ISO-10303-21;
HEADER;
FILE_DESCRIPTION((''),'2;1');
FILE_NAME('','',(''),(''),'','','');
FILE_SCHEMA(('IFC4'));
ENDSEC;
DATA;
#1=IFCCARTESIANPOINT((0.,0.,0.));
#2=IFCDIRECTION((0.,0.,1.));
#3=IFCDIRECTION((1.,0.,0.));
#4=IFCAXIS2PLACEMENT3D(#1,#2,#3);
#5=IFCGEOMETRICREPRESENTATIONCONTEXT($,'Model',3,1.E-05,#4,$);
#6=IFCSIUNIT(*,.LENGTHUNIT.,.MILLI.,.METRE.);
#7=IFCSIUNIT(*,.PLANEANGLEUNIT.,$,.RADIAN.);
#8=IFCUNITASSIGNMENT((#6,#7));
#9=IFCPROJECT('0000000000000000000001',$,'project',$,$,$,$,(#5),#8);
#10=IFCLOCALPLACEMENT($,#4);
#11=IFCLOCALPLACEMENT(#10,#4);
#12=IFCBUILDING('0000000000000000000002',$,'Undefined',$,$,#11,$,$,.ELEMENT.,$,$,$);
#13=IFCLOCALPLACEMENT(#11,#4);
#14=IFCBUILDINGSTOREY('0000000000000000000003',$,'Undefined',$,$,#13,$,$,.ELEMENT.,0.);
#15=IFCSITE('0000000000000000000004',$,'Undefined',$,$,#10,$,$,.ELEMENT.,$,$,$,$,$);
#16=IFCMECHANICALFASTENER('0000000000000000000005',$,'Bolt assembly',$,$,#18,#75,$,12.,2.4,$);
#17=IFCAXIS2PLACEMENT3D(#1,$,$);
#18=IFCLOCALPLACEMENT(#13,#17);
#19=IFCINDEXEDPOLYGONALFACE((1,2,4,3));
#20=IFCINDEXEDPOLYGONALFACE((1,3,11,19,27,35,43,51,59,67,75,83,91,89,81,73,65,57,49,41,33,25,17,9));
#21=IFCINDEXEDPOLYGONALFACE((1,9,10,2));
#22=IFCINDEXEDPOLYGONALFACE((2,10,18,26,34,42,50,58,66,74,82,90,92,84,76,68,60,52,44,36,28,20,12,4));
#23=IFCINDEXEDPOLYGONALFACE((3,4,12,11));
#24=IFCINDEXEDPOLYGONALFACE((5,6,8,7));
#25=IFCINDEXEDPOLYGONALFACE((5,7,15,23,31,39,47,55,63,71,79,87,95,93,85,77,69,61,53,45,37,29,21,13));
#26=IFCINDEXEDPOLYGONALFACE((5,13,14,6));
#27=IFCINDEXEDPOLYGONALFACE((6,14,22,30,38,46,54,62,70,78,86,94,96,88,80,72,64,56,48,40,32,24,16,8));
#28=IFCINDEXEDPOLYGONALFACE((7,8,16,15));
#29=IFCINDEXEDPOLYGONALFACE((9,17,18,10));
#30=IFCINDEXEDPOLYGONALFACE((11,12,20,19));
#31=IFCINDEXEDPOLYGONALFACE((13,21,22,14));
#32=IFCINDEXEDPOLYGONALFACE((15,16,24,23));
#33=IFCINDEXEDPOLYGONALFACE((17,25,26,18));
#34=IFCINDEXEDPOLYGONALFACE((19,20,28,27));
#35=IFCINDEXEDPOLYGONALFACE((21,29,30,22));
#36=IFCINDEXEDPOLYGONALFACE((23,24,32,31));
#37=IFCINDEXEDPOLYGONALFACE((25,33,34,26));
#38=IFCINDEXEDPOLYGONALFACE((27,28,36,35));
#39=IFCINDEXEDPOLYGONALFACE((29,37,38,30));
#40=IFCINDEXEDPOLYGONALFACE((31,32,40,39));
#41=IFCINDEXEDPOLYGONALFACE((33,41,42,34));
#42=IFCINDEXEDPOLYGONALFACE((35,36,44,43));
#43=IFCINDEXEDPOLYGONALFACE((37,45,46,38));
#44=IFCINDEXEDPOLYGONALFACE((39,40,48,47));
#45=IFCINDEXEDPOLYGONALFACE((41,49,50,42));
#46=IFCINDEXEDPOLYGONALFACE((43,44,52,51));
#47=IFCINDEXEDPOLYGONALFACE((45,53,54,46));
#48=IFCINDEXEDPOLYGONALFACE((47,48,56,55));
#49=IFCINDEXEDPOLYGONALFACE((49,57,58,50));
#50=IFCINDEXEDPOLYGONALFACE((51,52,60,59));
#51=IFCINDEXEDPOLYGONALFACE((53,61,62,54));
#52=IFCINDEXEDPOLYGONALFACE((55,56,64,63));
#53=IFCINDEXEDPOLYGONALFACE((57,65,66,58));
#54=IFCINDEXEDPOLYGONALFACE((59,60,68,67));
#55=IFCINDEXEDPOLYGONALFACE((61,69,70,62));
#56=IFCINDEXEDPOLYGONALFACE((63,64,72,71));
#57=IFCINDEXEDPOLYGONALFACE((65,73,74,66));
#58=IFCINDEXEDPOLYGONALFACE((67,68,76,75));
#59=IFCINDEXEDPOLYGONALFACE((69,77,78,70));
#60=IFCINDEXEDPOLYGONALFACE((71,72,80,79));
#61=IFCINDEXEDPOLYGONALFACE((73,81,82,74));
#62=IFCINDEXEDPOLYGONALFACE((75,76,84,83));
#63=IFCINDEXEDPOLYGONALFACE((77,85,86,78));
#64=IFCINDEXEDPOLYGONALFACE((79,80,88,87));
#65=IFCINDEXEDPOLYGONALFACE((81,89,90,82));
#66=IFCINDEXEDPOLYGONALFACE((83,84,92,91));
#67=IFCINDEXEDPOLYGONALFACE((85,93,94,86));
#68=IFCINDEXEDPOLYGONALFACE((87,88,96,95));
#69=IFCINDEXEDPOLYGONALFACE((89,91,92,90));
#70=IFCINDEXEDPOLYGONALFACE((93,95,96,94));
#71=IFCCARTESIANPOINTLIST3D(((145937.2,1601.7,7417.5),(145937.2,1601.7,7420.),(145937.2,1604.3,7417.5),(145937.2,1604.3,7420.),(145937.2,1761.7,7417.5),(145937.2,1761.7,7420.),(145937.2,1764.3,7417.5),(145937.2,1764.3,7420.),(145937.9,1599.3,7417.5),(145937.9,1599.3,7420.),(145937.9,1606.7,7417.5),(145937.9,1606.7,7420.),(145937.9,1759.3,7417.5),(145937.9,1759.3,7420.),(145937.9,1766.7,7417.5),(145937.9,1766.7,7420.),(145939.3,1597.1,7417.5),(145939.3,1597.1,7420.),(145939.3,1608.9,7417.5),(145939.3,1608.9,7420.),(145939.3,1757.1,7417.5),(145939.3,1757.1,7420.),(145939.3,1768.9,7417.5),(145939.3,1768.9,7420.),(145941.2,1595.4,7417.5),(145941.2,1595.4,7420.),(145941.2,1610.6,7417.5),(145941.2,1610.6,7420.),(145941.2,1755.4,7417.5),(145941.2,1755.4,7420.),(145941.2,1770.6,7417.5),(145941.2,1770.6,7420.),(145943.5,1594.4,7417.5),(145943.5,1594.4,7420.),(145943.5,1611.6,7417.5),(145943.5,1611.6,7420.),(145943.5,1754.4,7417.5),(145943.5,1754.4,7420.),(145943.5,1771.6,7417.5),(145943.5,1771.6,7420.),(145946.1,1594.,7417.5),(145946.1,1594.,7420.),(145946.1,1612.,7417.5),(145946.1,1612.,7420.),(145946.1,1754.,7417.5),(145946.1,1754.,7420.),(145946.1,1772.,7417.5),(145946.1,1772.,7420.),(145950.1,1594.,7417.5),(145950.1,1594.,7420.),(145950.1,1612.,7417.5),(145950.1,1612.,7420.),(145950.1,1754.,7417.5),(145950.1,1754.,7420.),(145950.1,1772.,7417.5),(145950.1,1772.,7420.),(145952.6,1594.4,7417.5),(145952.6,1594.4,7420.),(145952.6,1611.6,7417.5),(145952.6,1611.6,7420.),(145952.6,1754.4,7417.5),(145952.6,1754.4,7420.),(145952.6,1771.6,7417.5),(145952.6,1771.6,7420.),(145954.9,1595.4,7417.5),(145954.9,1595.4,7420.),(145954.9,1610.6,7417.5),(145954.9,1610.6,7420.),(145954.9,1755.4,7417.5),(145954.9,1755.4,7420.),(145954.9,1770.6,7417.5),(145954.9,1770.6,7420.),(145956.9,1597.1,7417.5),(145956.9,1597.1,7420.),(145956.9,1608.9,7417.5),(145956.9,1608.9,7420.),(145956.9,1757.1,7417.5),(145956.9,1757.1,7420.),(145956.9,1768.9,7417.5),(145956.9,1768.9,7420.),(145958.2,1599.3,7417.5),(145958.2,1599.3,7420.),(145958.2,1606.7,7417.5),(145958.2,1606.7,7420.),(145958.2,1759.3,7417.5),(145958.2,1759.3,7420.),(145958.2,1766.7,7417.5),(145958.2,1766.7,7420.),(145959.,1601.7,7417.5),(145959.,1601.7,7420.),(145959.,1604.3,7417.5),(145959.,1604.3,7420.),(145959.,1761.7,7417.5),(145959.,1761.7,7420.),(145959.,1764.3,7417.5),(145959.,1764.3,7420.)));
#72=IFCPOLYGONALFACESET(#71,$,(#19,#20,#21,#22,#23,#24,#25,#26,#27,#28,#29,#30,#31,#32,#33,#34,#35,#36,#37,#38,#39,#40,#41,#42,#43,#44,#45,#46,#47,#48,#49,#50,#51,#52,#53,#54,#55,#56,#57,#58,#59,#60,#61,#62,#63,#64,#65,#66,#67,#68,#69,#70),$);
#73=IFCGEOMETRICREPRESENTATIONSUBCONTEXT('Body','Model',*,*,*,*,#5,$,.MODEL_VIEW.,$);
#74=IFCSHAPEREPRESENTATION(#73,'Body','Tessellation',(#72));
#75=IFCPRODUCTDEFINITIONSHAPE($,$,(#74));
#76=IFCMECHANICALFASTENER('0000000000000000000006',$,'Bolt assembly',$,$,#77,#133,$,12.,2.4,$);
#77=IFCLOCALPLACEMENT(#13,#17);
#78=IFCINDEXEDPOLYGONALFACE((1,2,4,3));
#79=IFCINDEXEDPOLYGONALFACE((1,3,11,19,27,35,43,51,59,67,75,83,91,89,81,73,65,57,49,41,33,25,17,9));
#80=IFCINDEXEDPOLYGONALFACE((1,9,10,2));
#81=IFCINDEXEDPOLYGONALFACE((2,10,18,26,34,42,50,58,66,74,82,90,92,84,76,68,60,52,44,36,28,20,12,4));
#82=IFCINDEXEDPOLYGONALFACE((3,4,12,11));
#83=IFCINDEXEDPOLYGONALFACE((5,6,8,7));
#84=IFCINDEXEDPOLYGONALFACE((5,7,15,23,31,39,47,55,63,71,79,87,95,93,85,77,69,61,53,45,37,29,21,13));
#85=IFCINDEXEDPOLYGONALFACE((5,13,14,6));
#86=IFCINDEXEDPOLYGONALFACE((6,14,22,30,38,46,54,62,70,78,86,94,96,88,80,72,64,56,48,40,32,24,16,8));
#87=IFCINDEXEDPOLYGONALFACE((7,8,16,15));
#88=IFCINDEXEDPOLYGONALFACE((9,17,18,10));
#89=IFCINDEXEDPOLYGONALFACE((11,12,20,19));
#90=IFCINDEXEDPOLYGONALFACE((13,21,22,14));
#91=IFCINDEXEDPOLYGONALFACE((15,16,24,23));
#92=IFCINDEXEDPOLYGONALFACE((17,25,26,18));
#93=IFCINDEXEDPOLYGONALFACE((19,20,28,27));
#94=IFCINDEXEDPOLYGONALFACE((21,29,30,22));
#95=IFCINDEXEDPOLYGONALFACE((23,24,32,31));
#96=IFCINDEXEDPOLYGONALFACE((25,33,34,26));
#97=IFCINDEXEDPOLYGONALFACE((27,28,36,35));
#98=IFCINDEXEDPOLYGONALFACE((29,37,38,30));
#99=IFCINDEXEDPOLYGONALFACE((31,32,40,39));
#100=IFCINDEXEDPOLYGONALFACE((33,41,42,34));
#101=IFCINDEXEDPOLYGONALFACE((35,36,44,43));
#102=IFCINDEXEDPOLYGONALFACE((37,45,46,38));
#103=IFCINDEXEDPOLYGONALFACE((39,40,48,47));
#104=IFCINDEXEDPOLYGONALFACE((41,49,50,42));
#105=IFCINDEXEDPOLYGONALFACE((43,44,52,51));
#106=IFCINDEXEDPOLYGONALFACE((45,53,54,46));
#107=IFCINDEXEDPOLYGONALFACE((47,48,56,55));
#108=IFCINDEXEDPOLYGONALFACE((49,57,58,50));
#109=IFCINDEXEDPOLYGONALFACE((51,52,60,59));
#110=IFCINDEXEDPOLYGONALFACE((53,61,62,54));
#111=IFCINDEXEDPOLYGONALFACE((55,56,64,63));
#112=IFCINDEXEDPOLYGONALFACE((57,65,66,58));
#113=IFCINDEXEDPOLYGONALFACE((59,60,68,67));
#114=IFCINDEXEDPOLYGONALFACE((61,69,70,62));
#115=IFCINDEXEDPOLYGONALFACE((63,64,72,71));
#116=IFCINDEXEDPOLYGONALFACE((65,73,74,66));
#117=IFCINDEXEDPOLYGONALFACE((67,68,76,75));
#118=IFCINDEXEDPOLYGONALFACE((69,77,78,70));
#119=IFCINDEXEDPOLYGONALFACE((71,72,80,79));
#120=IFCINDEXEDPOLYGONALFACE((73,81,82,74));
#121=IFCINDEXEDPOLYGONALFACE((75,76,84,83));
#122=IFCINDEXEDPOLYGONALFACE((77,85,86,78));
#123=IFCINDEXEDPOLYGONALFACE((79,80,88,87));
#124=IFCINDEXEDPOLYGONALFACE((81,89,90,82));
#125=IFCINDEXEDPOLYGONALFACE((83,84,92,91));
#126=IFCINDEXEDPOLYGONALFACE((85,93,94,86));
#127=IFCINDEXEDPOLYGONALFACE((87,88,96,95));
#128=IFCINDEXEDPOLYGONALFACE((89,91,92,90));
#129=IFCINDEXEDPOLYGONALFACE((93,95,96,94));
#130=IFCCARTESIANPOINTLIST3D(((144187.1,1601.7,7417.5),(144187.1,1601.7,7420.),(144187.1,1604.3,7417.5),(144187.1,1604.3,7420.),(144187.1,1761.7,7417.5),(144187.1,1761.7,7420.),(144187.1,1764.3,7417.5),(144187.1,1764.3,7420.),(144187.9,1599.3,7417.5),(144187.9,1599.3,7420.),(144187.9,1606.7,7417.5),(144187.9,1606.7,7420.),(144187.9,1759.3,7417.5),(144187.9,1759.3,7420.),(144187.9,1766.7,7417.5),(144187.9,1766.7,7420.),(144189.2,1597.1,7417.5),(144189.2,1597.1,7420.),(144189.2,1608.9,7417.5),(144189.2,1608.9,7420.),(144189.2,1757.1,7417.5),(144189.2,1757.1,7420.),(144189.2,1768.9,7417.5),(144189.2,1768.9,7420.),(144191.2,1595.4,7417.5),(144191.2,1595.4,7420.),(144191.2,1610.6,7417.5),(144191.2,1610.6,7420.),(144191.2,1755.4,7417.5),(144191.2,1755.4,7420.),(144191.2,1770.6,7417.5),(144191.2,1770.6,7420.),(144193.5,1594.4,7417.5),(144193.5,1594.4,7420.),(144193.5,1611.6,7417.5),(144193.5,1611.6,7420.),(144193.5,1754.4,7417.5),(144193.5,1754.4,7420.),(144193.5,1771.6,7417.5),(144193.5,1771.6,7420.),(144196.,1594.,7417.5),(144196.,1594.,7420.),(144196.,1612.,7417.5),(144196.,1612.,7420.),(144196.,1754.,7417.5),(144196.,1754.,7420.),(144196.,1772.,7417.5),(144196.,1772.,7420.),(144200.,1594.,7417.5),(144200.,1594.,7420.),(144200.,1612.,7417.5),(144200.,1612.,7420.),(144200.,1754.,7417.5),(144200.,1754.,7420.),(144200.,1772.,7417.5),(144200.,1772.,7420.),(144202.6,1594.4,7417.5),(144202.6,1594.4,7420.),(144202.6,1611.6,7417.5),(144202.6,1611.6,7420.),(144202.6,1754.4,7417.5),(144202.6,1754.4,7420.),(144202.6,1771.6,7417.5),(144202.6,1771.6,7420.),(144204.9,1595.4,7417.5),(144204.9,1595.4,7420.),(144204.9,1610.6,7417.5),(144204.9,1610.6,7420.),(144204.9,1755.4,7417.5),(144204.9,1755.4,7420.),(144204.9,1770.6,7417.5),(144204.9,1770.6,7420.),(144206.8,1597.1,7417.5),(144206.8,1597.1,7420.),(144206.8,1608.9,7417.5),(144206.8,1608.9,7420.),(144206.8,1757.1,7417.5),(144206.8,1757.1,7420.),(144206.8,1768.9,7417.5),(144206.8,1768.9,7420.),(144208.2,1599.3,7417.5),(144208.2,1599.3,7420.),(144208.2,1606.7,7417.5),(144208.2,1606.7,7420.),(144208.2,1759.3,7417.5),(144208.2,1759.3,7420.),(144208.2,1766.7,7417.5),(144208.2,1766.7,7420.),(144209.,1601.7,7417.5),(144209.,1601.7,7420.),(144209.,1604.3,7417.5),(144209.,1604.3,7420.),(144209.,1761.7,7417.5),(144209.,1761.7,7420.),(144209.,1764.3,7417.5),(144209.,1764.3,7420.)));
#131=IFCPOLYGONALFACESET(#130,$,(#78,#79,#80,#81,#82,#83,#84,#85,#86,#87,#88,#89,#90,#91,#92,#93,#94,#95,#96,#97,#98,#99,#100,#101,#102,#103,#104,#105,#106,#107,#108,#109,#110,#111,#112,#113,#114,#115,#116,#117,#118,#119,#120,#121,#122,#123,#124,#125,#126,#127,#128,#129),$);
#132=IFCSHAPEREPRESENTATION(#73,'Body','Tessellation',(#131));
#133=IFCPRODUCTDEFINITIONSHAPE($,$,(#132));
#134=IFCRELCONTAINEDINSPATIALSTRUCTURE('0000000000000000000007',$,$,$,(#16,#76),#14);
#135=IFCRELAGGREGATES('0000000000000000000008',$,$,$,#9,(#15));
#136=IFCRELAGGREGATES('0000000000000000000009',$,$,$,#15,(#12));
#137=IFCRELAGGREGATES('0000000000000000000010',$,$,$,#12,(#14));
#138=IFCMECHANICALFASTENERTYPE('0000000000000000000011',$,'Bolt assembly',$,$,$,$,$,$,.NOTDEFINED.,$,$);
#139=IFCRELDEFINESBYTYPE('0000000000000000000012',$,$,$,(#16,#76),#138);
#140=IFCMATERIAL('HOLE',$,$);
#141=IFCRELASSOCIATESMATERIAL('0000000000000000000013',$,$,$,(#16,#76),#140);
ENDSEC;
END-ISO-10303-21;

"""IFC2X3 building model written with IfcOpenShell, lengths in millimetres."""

from ifc_helpers import new_model, si_unit, frame, frame_2d, origin_with_axes, place, context, subcontext, project, spatial, polyline, circle_curve, parameter, trimmed, segment, composite_curve, outline, extrude, source, transform, mapped, material, type_object, element, save


model = new_model("IFC2X3")

# Units and contexts
model_context = context("Model", 3, precision=1e-05, world=origin_with_axes())
body_context = subcontext(model_context, "Body", "Model", "MODEL_VIEW")
ifc_project = project(units=[si_unit("LENGTHUNIT", "METRE", prefix="MILLI"), si_unit("PLANEANGLEUNIT", "RADIAN")], contexts=[model_context])

# Site, building, storey
site_placement = place(None, origin_with_axes())
site = spatial("IfcSite", under=ifc_project, at=site_placement, Name="Undefined", CompositionType="ELEMENT")
building_placement = place(site_placement, origin_with_axes())
building = spatial("IfcBuilding", under=site, at=building_placement, Name="Undefined", CompositionType="ELEMENT")
storey_placement = place(building_placement, origin_with_axes())
storey = spatial("IfcBuildingStorey", under=building, at=storey_placement, Name="Undefined", CompositionType="ELEMENT", Elevation=0.0)

# Mechanical fasteners
mechanical_fastener_type = type_object("IfcMechanicalFastenerType", Name="Bolt assembly")
ifc_material_1 = material(Name="HOLE")
shared_shape_1 = source(origin_with_axes(), body_context, "Body", "SweptSolid", [
    extrude(outline(composite_curve([segment(polyline([(-2.0, 9.0), (2.0, 9.0)]), True, "CONTINUOUS"), segment(trimmed(circle_curve(frame_2d((2.0, 0.0), x_axis=(0.0, 1.0)), 9.0), [parameter(0.0)], [parameter(3.141593)], False, "PARAMETER"), True, "CONTINUOUS"), segment(polyline([(2.0, -9.0), (-2.0, -9.0)]), True, "CONTINUOUS"), segment(trimmed(circle_curve(frame_2d((-2.0, 0.0), x_axis=(0.0, -1.0)), 9.0), [parameter(0.0)], [parameter(3.141593)], False, "PARAMETER"), True, "DISCONTINUOUS")], self_intersect=False)), frame((0.0, -2.4, 0.0), z_axis=(0.0, 1.0, 0.0), x_axis=(1.0, 0.0, 0.0)), (0.0, 0.0, 1.0), 2.5),
])
mechanical_fastener_1_placement = place(storey_placement, frame((145948.1, 1683.0, 7417.6), z_axis=(0.0, -1.0, 0.0), x_axis=(-1.0, 0.0, 0.0)))
element("IfcMechanicalFastener", 1, at=mechanical_fastener_1_placement, inside=storey, type_object=mechanical_fastener_type, material=ifc_material_1, Name="Bolt assembly", NominalDiameter=12.0, NominalLength=2.4, context=body_context, shape_type="MappedRepresentation", body=[
    mapped(shared_shape_1, transform((0.0, 0.0, -80.0))),
    mapped(shared_shape_1, transform((0.0, 0.0, 80.0))),
])
shared_shape_2 = source(origin_with_axes(), body_context, "Body", "SweptSolid", [
    extrude(outline(composite_curve([segment(polyline([(-2.0, 9.0), (2.0, 9.0)]), True, "CONTINUOUS"), segment(trimmed(circle_curve(frame_2d((2.0, 0.0), x_axis=(0.0, 1.0)), 9.0), [parameter(0.0)], [parameter(3.141593)], False, "PARAMETER"), True, "CONTINUOUS"), segment(polyline([(2.0, -9.0), (-2.0, -9.0)]), True, "CONTINUOUS"), segment(trimmed(circle_curve(frame_2d((-2.0, 0.0), x_axis=(0.0, -1.0)), 9.0), [parameter(0.0)], [parameter(3.141593)], False, "PARAMETER"), True, "DISCONTINUOUS")], self_intersect=False)), frame((0.0, -2.4, 0.0), z_axis=(0.0, 1.0, 0.0), x_axis=(1.0, 0.0, 0.0)), (0.0, 0.0, 1.0), 2.5),
])
mechanical_fastener_2_placement = place(storey_placement, frame((144198.0, 1683.0, 7417.6), z_axis=(0.0, -1.0, 0.0), x_axis=(-1.0, 0.0, 0.0)))
element("IfcMechanicalFastener", 2, at=mechanical_fastener_2_placement, inside=storey, type_object=mechanical_fastener_type, material=ifc_material_1, Name="Bolt assembly", NominalDiameter=12.0, NominalLength=2.4, context=body_context, shape_type="MappedRepresentation", body=[
    mapped(shared_shape_2, transform((0.0, 0.0, -80.0))),
    mapped(shared_shape_2, transform((0.0, 0.0, 80.0))),
])

save(model, "model.ifc")
